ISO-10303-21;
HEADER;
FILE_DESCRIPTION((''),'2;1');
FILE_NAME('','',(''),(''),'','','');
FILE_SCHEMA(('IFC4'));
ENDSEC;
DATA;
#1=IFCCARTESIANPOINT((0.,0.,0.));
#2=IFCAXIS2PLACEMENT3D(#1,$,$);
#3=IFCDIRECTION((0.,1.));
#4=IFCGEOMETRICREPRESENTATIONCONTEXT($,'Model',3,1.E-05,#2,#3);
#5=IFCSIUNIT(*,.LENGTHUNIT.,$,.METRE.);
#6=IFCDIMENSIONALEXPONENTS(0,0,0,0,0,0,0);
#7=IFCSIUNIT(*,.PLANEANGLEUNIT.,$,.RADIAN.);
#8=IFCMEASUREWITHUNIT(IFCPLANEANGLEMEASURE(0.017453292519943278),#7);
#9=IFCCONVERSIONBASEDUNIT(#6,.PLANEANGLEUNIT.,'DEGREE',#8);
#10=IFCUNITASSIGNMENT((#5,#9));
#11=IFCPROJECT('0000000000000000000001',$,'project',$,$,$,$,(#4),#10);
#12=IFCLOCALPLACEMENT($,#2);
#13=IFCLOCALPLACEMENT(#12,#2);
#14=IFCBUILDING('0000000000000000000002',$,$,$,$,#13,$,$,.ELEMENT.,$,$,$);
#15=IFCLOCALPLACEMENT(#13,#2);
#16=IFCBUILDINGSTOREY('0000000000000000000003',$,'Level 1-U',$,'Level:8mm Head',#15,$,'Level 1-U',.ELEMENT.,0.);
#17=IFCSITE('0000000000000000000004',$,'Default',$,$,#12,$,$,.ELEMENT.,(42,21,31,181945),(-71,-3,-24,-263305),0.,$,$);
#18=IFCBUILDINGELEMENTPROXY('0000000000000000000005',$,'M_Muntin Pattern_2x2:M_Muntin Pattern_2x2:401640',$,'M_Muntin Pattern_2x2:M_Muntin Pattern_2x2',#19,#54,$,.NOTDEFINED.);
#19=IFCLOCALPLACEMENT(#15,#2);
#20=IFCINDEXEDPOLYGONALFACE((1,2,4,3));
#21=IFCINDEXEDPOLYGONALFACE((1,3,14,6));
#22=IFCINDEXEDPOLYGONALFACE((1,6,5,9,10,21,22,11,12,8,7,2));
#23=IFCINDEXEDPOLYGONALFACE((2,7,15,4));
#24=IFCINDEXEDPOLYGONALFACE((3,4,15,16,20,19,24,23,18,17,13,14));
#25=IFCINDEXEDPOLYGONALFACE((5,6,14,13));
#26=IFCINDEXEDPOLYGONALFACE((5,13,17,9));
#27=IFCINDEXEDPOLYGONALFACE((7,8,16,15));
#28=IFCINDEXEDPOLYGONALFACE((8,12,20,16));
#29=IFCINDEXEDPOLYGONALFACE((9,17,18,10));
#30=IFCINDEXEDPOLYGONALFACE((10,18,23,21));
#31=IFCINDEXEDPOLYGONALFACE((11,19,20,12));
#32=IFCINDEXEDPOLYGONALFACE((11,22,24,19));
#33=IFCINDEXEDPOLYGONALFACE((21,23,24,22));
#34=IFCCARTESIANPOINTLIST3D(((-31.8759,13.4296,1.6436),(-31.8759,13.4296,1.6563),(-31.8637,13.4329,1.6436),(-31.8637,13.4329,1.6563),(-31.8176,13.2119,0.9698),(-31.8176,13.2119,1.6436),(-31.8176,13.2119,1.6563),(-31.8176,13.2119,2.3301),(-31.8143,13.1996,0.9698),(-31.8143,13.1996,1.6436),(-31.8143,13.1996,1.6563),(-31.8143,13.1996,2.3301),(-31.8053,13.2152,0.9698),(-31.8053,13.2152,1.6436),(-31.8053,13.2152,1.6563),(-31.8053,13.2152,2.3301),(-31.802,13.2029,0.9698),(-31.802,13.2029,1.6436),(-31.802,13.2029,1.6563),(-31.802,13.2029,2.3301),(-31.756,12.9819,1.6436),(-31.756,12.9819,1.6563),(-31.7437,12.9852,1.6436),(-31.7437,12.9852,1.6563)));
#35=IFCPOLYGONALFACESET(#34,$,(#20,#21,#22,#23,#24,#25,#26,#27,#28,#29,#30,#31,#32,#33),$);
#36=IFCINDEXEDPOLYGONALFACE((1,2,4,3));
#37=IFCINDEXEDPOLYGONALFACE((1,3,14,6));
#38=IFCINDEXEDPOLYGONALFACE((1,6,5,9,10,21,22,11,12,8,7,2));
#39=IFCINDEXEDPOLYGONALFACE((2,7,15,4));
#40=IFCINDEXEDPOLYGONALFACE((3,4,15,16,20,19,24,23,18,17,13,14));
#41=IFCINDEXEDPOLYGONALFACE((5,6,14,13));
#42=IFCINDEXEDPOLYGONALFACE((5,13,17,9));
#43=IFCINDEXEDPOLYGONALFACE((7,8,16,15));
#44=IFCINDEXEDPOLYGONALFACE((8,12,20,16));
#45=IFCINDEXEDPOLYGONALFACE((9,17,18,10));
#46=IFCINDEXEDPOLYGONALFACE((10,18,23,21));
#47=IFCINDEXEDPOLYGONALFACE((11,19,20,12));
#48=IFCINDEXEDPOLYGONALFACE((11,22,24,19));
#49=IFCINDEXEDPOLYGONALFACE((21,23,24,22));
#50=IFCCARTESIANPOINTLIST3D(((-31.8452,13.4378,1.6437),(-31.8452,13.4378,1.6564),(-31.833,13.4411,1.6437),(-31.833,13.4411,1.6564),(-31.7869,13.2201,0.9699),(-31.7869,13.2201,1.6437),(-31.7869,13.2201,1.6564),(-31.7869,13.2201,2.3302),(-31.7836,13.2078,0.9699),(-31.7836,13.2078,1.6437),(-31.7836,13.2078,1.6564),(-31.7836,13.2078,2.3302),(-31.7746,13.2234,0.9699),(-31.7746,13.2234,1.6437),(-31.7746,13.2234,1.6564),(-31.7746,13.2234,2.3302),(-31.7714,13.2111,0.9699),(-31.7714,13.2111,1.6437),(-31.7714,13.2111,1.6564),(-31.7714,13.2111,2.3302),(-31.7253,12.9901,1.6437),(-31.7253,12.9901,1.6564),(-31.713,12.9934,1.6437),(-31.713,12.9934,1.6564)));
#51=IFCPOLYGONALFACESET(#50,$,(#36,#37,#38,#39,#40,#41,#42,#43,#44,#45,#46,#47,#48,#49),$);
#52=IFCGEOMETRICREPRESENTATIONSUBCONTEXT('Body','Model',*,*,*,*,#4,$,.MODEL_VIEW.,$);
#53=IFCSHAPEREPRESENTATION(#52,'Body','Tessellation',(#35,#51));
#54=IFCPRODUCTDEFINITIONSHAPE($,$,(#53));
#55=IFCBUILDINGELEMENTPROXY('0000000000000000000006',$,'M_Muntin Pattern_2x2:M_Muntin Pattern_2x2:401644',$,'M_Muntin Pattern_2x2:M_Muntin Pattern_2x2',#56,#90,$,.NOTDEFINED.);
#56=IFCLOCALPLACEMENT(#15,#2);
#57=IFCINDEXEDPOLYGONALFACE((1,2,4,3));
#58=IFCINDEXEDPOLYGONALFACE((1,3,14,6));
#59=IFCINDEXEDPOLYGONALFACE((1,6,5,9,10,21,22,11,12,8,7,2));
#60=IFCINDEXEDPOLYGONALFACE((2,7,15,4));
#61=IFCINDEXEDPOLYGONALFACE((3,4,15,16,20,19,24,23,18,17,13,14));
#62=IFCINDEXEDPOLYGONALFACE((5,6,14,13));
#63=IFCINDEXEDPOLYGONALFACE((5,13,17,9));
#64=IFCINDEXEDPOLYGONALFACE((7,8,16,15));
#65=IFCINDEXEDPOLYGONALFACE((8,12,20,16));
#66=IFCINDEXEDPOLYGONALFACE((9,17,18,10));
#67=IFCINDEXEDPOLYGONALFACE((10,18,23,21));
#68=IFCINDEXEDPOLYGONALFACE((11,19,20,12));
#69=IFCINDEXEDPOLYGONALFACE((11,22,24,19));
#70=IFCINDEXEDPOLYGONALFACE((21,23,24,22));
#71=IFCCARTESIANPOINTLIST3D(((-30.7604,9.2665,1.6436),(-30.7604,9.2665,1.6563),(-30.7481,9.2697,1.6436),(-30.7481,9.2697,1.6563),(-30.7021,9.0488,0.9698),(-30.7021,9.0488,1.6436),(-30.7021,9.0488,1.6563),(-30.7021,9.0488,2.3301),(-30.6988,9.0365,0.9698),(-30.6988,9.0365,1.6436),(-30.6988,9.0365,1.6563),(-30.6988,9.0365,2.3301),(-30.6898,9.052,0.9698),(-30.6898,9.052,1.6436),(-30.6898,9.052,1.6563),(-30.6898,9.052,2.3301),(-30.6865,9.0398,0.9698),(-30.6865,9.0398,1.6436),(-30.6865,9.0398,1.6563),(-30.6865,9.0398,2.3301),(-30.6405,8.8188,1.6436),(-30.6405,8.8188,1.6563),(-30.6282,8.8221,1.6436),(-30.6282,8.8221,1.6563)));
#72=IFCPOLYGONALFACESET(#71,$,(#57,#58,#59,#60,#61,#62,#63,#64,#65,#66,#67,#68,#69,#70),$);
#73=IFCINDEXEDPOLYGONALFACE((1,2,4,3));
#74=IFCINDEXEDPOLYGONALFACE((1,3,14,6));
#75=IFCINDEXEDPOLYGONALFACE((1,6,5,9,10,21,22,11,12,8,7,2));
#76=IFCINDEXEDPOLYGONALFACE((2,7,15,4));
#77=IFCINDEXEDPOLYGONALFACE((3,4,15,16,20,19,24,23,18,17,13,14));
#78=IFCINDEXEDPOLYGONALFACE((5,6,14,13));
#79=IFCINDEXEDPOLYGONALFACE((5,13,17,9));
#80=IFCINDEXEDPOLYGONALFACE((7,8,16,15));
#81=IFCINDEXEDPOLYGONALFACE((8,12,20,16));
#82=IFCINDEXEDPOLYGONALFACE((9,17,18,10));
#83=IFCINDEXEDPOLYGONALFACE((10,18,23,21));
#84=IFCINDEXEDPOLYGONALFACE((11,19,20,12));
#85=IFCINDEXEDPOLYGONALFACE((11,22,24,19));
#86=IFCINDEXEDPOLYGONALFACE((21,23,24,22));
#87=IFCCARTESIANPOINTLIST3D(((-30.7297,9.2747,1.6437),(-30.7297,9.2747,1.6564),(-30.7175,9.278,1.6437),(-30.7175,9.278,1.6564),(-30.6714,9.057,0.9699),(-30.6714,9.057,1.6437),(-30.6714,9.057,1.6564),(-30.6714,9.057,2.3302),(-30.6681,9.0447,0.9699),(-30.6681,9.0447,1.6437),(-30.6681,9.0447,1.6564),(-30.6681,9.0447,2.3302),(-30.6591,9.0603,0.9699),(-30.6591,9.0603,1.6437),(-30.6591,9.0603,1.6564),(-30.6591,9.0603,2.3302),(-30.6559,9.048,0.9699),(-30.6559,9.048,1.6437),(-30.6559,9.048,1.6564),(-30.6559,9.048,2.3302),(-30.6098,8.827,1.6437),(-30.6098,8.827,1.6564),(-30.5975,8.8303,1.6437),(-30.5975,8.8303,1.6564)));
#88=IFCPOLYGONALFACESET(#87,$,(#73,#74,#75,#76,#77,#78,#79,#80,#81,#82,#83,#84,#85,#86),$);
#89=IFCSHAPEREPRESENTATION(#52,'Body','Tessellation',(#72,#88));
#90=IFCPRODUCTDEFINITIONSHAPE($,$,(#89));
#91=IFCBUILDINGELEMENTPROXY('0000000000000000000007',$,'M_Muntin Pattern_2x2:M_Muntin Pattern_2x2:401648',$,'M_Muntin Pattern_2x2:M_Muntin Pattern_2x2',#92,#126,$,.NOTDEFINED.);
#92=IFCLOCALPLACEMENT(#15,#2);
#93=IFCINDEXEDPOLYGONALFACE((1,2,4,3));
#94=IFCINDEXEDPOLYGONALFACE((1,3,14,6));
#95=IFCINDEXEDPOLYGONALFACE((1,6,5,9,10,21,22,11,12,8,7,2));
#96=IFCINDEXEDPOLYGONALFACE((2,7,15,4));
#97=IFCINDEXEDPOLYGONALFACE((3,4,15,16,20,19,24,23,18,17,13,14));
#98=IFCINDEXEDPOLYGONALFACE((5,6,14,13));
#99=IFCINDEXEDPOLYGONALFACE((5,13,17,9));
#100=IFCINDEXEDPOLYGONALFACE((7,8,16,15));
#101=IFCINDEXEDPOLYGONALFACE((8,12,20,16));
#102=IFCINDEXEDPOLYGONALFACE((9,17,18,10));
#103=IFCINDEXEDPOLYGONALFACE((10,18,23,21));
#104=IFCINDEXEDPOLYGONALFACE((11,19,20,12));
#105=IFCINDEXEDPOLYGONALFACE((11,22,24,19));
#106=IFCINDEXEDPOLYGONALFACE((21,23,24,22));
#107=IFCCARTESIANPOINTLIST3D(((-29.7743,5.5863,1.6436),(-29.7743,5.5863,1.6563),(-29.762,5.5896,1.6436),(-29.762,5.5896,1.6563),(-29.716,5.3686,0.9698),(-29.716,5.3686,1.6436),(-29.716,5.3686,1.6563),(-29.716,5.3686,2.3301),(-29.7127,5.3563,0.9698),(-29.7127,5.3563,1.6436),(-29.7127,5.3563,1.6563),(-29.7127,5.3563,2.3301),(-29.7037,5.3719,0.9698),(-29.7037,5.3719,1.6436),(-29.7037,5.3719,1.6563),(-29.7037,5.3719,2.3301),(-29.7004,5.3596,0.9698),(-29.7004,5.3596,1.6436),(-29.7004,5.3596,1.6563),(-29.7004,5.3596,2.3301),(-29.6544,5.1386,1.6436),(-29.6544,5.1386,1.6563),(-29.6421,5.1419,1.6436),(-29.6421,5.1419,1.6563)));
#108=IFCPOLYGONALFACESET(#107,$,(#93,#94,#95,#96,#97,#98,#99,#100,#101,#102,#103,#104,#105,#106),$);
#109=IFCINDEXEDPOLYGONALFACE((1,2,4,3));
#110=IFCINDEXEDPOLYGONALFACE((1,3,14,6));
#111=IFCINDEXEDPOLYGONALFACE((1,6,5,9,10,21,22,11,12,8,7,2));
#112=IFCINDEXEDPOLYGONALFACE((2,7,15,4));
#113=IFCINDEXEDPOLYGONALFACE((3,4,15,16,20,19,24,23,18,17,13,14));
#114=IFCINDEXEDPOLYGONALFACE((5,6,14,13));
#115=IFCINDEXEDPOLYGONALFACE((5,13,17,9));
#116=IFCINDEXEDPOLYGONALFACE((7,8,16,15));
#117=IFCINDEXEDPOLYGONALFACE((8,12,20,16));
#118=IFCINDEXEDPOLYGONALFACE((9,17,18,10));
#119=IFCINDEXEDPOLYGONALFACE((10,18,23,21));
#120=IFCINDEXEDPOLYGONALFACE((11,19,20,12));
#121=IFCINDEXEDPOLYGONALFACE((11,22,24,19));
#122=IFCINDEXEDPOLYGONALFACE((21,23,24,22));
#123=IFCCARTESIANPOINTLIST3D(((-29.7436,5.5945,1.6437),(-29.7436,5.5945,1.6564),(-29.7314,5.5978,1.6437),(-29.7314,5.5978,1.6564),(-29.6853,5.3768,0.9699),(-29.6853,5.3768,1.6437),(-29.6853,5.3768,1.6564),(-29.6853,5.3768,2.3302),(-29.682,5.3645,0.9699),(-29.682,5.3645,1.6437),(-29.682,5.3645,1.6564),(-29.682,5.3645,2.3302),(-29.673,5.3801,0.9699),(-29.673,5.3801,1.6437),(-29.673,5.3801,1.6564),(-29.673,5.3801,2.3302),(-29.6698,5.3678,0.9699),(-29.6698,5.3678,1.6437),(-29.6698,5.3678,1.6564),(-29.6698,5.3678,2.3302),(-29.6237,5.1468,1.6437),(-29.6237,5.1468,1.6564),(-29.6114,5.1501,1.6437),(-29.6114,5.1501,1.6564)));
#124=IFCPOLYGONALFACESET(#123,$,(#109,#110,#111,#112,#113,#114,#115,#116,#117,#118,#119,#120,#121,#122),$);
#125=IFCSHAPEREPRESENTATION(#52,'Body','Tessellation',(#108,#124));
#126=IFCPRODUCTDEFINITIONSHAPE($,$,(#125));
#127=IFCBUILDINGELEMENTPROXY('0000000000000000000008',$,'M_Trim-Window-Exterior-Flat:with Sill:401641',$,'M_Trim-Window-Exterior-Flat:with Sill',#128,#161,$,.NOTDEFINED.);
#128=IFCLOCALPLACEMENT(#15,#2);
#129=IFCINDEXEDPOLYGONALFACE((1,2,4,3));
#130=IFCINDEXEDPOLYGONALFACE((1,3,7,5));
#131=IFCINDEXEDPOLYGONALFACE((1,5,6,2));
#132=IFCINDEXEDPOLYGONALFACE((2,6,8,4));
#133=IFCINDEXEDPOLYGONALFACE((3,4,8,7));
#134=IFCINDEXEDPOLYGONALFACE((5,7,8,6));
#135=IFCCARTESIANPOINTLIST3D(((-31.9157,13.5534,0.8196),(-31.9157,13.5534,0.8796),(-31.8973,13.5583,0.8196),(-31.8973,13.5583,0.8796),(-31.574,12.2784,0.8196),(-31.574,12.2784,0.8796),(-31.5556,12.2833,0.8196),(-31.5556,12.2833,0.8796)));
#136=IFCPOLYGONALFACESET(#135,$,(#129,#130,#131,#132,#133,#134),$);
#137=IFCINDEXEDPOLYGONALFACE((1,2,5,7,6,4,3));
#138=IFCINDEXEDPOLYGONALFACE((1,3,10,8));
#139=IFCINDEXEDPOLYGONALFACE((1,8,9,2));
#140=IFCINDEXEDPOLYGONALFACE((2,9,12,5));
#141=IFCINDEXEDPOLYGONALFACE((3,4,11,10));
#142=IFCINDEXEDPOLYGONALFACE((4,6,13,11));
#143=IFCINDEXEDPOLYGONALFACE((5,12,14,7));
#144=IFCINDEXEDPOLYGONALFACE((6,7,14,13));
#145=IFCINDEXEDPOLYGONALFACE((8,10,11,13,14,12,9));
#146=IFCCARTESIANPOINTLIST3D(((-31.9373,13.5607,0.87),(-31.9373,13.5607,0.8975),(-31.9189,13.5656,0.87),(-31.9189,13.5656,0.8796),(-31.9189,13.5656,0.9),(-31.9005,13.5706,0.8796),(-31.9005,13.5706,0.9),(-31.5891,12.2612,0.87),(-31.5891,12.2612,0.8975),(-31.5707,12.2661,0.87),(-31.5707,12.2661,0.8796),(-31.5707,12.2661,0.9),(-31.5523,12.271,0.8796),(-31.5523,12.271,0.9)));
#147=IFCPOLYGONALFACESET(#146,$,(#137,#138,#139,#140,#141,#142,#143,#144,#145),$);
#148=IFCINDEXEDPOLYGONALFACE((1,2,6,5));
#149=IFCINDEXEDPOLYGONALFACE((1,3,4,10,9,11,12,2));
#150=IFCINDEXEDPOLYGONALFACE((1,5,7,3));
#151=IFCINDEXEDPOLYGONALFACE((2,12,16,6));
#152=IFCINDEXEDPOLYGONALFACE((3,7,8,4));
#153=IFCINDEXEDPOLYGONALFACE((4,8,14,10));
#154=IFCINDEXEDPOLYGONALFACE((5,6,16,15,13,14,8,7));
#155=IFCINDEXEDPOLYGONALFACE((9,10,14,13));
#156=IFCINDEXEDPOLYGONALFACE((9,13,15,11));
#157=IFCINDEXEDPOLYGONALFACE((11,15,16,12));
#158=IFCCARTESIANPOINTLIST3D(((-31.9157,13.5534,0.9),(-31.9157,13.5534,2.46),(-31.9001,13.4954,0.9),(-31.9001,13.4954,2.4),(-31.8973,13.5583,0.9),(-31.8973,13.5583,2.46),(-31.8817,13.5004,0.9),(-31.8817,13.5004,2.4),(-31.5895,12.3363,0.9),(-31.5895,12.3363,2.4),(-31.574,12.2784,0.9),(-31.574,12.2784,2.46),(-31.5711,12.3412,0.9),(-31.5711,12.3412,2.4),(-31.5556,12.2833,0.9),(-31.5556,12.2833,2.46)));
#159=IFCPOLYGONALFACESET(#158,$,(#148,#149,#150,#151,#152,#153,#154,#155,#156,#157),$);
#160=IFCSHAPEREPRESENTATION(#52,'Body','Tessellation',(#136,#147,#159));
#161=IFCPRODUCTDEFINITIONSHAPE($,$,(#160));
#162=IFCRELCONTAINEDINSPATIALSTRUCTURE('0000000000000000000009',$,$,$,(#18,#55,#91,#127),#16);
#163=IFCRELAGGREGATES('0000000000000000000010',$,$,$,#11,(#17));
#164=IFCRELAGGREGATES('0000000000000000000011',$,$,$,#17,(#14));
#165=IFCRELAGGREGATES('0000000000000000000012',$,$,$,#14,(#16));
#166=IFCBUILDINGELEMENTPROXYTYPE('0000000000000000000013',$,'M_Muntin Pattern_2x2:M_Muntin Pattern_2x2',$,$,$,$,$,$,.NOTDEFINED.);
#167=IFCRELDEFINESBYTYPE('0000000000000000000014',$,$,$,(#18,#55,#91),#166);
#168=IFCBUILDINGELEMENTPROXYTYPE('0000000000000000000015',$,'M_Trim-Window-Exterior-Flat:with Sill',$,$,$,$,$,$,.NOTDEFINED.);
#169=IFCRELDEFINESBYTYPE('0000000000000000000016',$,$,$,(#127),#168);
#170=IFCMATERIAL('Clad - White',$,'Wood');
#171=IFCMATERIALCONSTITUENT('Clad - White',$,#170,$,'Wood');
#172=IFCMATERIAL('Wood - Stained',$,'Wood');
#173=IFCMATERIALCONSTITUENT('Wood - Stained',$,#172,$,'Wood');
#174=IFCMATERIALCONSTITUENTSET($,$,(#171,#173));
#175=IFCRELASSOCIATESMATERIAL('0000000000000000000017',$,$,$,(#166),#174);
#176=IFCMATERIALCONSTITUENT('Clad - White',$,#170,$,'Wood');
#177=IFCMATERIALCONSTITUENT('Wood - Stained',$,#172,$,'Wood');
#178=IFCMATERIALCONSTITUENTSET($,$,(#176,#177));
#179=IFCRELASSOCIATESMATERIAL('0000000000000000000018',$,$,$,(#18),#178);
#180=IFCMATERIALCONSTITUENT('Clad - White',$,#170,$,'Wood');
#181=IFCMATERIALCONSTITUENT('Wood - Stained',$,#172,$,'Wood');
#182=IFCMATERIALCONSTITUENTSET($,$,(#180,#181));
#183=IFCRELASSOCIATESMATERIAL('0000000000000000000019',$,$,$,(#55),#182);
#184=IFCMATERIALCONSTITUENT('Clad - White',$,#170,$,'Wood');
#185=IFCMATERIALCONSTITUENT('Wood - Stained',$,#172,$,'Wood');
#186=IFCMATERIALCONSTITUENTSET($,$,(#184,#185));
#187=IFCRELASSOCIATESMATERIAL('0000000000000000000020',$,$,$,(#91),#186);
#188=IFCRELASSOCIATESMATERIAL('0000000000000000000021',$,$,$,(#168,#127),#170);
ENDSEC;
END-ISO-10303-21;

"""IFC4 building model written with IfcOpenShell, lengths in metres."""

from ifc_helpers import new_model, entity, si_unit, converted_unit, direction, frame, origin, place, context, subcontext, project, spatial, indexed_curve, outline, extrude, source, transform, mapped, material, constituent, constituent_set, type_object, type_shapes, element, save


model = new_model("IFC4")

# Units and contexts
model_context = context("Model", 3, precision=1e-05, world=origin(), true_north=direction((0.0, 1.0)))
body_context = subcontext(model_context, "Body", "Model", "MODEL_VIEW")
ifc_project = project(units=[si_unit("LENGTHUNIT", "METRE"), converted_unit("PLANEANGLEUNIT", "DEGREE", entity("IfcPlaneAngleMeasure", 0.017453292519943278), si_unit("PLANEANGLEUNIT", "RADIAN"), dimensions=[0, 0, 0, 0, 0, 0, 0])], contexts=[model_context])

# Site, building, storey
site_placement = place(None, origin())
site = spatial("IfcSite", under=ifc_project, at=site_placement, Name="Default", CompositionType="ELEMENT", RefLatitude=(42, 21, 31, 181945), RefLongitude=(-71, -3, -24, -263305), RefElevation=0.0)
building_placement = place(site_placement, origin())
building = spatial("IfcBuilding", under=site, at=building_placement, CompositionType="ELEMENT")
storey_placement = place(building_placement, origin())
storey = spatial("IfcBuildingStorey", under=building, at=storey_placement, Name="Level 1-U", ObjectType="Level:8mm Head", LongName="Level 1-U", CompositionType="ELEMENT", Elevation=0.0)

# Building element proxies
ifc_material_1 = material(Name="Clad - White", Category="Wood")
ifc_material_2 = material(Name="Wood - Stained", Category="Wood")
ifc_constituent_1 = constituent(ifc_material_1, Name="Clad - White", Category="Wood")
ifc_constituent_2 = constituent(ifc_material_2, Name="Wood - Stained", Category="Wood")
ifc_constituent_set_1 = constituent_set(constituents=[ifc_constituent_1, ifc_constituent_2])
ifc_constituent_3 = constituent(ifc_material_1, Name="Clad - White", Category="Wood")
ifc_constituent_4 = constituent(ifc_material_2, Name="Wood - Stained", Category="Wood")
ifc_constituent_set_2 = constituent_set(constituents=[ifc_constituent_3, ifc_constituent_4])
building_element_proxy_type_1 = type_object("IfcBuildingElementProxyType", Name="M_Muntin Pattern_2x2:M_Muntin Pattern_2x2", PredefinedType="NOTDEFINED", material=ifc_constituent_set_2)
shared_shape_1 = source(origin(), body_context, "Body", "SweptSolid", [
    extrude(outline(indexed_curve([(0.0064, -0.0064), (0.6801, -0.0064), (0.6801, 0.0063), (0.0064, 0.0063), (0.0064, 0.2317), (-0.0063, 0.2317), (-0.0063, 0.0063), (-0.6802, 0.0063), (-0.6802, -0.0064), (-0.0063, -0.0064), (-0.0063, -0.2317), (0.0064, -0.2317), (0.0064, -0.0064)], self_intersect=False)), frame((0.0, -0.0222, 0.6801), z_axis=(0.0, 1.0, 0.0), x_axis=(0.0, 0.0, 1.0)), (0.0, 0.0, 1.0), 0.0127),
    extrude(outline(indexed_curve([(0.0064, -0.0064), (0.6802, -0.0064), (0.6802, 0.0063), (0.0064, 0.0063), (0.0064, 0.2317), (-0.0063, 0.2317), (-0.0063, 0.0063), (-0.6802, 0.0063), (-0.6802, -0.0064), (-0.0063, -0.0064), (-0.0063, -0.2317), (0.0064, -0.2317), (0.0064, -0.0064)], self_intersect=False)), frame((0.0, 0.0095, 0.6802), z_axis=(0.0, 1.0, 0.0), x_axis=(0.0, 0.0, 1.0)), (0.0, 0.0, 1.0), 0.0127),
])
type_shapes(building_element_proxy_type_1, [shared_shape_1])
proxy_1_placement = place(storey_placement, frame((-31.7945, 13.2115, 0.9699), z_axis=(0.0, 0.0, 1.0), x_axis=(0.258819, -0.965926, 0.0)))
element("IfcBuildingElementProxy", 1, at=proxy_1_placement, inside=storey, type_object=building_element_proxy_type_1, material=ifc_constituent_set_1, Name="M_Muntin Pattern_2x2:M_Muntin Pattern_2x2:401640", ObjectType="M_Muntin Pattern_2x2:M_Muntin Pattern_2x2", PredefinedType="NOTDEFINED", context=body_context, shape_type="MappedRepresentation", body=[
    mapped(shared_shape_1, transform((0.0, 0.0, 0.0), scale=1.0)),
])
ifc_constituent_5 = constituent(ifc_material_1, Name="Clad - White", Category="Wood")
ifc_constituent_6 = constituent(ifc_material_2, Name="Wood - Stained", Category="Wood")
ifc_constituent_set_3 = constituent_set(constituents=[ifc_constituent_5, ifc_constituent_6])
proxy_2_placement = place(storey_placement, frame((-30.679, 9.0484, 0.9699), z_axis=(0.0, 0.0, 1.0), x_axis=(0.258819, -0.965926, 0.0)))
element("IfcBuildingElementProxy", 2, at=proxy_2_placement, inside=storey, type_object=building_element_proxy_type_1, material=ifc_constituent_set_3, Name="M_Muntin Pattern_2x2:M_Muntin Pattern_2x2:401644", ObjectType="M_Muntin Pattern_2x2:M_Muntin Pattern_2x2", PredefinedType="NOTDEFINED", context=body_context, shape_type="MappedRepresentation", body=[
    mapped(shared_shape_1, transform((0.0, 0.0, 0.0), scale=1.0)),
])
ifc_constituent_7 = constituent(ifc_material_1, Name="Clad - White", Category="Wood")
ifc_constituent_8 = constituent(ifc_material_2, Name="Wood - Stained", Category="Wood")
ifc_constituent_set_4 = constituent_set(constituents=[ifc_constituent_7, ifc_constituent_8])
proxy_3_placement = place(storey_placement, frame((-29.6929, 5.3682, 0.9699), z_axis=(0.0, 0.0, 1.0), x_axis=(0.258819, -0.965926, 0.0)))
element("IfcBuildingElementProxy", 3, at=proxy_3_placement, inside=storey, type_object=building_element_proxy_type_1, material=ifc_constituent_set_4, Name="M_Muntin Pattern_2x2:M_Muntin Pattern_2x2:401648", ObjectType="M_Muntin Pattern_2x2:M_Muntin Pattern_2x2", PredefinedType="NOTDEFINED", context=body_context, shape_type="MappedRepresentation", body=[
    mapped(shared_shape_1, transform((0.0, 0.0, 0.0), scale=1.0)),
])
building_element_proxy_type_2 = type_object("IfcBuildingElementProxyType", Name="M_Trim-Window-Exterior-Flat:with Sill", PredefinedType="NOTDEFINED", material=ifc_material_1)
shared_shape_2 = source(origin(), body_context, "Body", "SweptSolid", [
    extrude(outline(indexed_curve([(-0.66, -0.03), (0.66, -0.03), (0.66, 0.03), (-0.66, 0.03), (-0.66, -0.03)], self_intersect=False)), frame((0.0, -1.5504, 0.0), z_axis=(0.0, 0.0, 1.0), x_axis=(-1.0, 0.0, 0.0)), (0.0, 0.0, 1.0), 0.019),
    extrude(outline(indexed_curve([(-0.019, -0.0152), (0.0, -0.0152), (0.0, -0.0057), (0.019, -0.0057), (0.019, 0.0148), (0.0, 0.0148), (-0.019, 0.0123), (-0.019, -0.0152)], self_intersect=False)), frame((-0.6727, -1.5148, 0.019), z_axis=(1.0, 0.0, 0.0), x_axis=(0.0, 0.0, -1.0)), (0.0, 0.0, 1.0), 1.3454),
    extrude(outline(indexed_curve([(-0.795, -0.66), (0.765, -0.66), (0.765, -0.6), (-0.735, -0.6), (-0.735, 0.6), (0.765, 0.6), (0.765, 0.66), (-0.795, 0.66), (-0.795, -0.66)], self_intersect=False)), frame((0.0, -0.735, 0.0), z_axis=(0.0, 0.0, 1.0), x_axis=(0.0, -1.0, 0.0)), (0.0, 0.0, 1.0), 0.019),
])
type_shapes(building_element_proxy_type_2, [shared_shape_2])
for number, where, z_axis, x_axis, name in (
    (4, (-31.7264, 12.9208, 2.4), (-0.965926, -0.258819, 0.0), (0.258819, -0.965926, 0.0), "M_Trim-Window-Exterior-Flat:with Sill:401641"),
):
    element("IfcBuildingElementProxy", number, at=place(storey_placement, frame(where, z_axis=z_axis, x_axis=x_axis)), inside=storey, type_object=building_element_proxy_type_2, material=ifc_material_1, Name=name, ObjectType="M_Trim-Window-Exterior-Flat:with Sill", PredefinedType="NOTDEFINED", context=body_context, shape_type="MappedRepresentation", body=[
        mapped(shared_shape_2, transform((0.0, 0.0, 0.0), scale=1.0)),
    ])

save(model, "model.ifc")
